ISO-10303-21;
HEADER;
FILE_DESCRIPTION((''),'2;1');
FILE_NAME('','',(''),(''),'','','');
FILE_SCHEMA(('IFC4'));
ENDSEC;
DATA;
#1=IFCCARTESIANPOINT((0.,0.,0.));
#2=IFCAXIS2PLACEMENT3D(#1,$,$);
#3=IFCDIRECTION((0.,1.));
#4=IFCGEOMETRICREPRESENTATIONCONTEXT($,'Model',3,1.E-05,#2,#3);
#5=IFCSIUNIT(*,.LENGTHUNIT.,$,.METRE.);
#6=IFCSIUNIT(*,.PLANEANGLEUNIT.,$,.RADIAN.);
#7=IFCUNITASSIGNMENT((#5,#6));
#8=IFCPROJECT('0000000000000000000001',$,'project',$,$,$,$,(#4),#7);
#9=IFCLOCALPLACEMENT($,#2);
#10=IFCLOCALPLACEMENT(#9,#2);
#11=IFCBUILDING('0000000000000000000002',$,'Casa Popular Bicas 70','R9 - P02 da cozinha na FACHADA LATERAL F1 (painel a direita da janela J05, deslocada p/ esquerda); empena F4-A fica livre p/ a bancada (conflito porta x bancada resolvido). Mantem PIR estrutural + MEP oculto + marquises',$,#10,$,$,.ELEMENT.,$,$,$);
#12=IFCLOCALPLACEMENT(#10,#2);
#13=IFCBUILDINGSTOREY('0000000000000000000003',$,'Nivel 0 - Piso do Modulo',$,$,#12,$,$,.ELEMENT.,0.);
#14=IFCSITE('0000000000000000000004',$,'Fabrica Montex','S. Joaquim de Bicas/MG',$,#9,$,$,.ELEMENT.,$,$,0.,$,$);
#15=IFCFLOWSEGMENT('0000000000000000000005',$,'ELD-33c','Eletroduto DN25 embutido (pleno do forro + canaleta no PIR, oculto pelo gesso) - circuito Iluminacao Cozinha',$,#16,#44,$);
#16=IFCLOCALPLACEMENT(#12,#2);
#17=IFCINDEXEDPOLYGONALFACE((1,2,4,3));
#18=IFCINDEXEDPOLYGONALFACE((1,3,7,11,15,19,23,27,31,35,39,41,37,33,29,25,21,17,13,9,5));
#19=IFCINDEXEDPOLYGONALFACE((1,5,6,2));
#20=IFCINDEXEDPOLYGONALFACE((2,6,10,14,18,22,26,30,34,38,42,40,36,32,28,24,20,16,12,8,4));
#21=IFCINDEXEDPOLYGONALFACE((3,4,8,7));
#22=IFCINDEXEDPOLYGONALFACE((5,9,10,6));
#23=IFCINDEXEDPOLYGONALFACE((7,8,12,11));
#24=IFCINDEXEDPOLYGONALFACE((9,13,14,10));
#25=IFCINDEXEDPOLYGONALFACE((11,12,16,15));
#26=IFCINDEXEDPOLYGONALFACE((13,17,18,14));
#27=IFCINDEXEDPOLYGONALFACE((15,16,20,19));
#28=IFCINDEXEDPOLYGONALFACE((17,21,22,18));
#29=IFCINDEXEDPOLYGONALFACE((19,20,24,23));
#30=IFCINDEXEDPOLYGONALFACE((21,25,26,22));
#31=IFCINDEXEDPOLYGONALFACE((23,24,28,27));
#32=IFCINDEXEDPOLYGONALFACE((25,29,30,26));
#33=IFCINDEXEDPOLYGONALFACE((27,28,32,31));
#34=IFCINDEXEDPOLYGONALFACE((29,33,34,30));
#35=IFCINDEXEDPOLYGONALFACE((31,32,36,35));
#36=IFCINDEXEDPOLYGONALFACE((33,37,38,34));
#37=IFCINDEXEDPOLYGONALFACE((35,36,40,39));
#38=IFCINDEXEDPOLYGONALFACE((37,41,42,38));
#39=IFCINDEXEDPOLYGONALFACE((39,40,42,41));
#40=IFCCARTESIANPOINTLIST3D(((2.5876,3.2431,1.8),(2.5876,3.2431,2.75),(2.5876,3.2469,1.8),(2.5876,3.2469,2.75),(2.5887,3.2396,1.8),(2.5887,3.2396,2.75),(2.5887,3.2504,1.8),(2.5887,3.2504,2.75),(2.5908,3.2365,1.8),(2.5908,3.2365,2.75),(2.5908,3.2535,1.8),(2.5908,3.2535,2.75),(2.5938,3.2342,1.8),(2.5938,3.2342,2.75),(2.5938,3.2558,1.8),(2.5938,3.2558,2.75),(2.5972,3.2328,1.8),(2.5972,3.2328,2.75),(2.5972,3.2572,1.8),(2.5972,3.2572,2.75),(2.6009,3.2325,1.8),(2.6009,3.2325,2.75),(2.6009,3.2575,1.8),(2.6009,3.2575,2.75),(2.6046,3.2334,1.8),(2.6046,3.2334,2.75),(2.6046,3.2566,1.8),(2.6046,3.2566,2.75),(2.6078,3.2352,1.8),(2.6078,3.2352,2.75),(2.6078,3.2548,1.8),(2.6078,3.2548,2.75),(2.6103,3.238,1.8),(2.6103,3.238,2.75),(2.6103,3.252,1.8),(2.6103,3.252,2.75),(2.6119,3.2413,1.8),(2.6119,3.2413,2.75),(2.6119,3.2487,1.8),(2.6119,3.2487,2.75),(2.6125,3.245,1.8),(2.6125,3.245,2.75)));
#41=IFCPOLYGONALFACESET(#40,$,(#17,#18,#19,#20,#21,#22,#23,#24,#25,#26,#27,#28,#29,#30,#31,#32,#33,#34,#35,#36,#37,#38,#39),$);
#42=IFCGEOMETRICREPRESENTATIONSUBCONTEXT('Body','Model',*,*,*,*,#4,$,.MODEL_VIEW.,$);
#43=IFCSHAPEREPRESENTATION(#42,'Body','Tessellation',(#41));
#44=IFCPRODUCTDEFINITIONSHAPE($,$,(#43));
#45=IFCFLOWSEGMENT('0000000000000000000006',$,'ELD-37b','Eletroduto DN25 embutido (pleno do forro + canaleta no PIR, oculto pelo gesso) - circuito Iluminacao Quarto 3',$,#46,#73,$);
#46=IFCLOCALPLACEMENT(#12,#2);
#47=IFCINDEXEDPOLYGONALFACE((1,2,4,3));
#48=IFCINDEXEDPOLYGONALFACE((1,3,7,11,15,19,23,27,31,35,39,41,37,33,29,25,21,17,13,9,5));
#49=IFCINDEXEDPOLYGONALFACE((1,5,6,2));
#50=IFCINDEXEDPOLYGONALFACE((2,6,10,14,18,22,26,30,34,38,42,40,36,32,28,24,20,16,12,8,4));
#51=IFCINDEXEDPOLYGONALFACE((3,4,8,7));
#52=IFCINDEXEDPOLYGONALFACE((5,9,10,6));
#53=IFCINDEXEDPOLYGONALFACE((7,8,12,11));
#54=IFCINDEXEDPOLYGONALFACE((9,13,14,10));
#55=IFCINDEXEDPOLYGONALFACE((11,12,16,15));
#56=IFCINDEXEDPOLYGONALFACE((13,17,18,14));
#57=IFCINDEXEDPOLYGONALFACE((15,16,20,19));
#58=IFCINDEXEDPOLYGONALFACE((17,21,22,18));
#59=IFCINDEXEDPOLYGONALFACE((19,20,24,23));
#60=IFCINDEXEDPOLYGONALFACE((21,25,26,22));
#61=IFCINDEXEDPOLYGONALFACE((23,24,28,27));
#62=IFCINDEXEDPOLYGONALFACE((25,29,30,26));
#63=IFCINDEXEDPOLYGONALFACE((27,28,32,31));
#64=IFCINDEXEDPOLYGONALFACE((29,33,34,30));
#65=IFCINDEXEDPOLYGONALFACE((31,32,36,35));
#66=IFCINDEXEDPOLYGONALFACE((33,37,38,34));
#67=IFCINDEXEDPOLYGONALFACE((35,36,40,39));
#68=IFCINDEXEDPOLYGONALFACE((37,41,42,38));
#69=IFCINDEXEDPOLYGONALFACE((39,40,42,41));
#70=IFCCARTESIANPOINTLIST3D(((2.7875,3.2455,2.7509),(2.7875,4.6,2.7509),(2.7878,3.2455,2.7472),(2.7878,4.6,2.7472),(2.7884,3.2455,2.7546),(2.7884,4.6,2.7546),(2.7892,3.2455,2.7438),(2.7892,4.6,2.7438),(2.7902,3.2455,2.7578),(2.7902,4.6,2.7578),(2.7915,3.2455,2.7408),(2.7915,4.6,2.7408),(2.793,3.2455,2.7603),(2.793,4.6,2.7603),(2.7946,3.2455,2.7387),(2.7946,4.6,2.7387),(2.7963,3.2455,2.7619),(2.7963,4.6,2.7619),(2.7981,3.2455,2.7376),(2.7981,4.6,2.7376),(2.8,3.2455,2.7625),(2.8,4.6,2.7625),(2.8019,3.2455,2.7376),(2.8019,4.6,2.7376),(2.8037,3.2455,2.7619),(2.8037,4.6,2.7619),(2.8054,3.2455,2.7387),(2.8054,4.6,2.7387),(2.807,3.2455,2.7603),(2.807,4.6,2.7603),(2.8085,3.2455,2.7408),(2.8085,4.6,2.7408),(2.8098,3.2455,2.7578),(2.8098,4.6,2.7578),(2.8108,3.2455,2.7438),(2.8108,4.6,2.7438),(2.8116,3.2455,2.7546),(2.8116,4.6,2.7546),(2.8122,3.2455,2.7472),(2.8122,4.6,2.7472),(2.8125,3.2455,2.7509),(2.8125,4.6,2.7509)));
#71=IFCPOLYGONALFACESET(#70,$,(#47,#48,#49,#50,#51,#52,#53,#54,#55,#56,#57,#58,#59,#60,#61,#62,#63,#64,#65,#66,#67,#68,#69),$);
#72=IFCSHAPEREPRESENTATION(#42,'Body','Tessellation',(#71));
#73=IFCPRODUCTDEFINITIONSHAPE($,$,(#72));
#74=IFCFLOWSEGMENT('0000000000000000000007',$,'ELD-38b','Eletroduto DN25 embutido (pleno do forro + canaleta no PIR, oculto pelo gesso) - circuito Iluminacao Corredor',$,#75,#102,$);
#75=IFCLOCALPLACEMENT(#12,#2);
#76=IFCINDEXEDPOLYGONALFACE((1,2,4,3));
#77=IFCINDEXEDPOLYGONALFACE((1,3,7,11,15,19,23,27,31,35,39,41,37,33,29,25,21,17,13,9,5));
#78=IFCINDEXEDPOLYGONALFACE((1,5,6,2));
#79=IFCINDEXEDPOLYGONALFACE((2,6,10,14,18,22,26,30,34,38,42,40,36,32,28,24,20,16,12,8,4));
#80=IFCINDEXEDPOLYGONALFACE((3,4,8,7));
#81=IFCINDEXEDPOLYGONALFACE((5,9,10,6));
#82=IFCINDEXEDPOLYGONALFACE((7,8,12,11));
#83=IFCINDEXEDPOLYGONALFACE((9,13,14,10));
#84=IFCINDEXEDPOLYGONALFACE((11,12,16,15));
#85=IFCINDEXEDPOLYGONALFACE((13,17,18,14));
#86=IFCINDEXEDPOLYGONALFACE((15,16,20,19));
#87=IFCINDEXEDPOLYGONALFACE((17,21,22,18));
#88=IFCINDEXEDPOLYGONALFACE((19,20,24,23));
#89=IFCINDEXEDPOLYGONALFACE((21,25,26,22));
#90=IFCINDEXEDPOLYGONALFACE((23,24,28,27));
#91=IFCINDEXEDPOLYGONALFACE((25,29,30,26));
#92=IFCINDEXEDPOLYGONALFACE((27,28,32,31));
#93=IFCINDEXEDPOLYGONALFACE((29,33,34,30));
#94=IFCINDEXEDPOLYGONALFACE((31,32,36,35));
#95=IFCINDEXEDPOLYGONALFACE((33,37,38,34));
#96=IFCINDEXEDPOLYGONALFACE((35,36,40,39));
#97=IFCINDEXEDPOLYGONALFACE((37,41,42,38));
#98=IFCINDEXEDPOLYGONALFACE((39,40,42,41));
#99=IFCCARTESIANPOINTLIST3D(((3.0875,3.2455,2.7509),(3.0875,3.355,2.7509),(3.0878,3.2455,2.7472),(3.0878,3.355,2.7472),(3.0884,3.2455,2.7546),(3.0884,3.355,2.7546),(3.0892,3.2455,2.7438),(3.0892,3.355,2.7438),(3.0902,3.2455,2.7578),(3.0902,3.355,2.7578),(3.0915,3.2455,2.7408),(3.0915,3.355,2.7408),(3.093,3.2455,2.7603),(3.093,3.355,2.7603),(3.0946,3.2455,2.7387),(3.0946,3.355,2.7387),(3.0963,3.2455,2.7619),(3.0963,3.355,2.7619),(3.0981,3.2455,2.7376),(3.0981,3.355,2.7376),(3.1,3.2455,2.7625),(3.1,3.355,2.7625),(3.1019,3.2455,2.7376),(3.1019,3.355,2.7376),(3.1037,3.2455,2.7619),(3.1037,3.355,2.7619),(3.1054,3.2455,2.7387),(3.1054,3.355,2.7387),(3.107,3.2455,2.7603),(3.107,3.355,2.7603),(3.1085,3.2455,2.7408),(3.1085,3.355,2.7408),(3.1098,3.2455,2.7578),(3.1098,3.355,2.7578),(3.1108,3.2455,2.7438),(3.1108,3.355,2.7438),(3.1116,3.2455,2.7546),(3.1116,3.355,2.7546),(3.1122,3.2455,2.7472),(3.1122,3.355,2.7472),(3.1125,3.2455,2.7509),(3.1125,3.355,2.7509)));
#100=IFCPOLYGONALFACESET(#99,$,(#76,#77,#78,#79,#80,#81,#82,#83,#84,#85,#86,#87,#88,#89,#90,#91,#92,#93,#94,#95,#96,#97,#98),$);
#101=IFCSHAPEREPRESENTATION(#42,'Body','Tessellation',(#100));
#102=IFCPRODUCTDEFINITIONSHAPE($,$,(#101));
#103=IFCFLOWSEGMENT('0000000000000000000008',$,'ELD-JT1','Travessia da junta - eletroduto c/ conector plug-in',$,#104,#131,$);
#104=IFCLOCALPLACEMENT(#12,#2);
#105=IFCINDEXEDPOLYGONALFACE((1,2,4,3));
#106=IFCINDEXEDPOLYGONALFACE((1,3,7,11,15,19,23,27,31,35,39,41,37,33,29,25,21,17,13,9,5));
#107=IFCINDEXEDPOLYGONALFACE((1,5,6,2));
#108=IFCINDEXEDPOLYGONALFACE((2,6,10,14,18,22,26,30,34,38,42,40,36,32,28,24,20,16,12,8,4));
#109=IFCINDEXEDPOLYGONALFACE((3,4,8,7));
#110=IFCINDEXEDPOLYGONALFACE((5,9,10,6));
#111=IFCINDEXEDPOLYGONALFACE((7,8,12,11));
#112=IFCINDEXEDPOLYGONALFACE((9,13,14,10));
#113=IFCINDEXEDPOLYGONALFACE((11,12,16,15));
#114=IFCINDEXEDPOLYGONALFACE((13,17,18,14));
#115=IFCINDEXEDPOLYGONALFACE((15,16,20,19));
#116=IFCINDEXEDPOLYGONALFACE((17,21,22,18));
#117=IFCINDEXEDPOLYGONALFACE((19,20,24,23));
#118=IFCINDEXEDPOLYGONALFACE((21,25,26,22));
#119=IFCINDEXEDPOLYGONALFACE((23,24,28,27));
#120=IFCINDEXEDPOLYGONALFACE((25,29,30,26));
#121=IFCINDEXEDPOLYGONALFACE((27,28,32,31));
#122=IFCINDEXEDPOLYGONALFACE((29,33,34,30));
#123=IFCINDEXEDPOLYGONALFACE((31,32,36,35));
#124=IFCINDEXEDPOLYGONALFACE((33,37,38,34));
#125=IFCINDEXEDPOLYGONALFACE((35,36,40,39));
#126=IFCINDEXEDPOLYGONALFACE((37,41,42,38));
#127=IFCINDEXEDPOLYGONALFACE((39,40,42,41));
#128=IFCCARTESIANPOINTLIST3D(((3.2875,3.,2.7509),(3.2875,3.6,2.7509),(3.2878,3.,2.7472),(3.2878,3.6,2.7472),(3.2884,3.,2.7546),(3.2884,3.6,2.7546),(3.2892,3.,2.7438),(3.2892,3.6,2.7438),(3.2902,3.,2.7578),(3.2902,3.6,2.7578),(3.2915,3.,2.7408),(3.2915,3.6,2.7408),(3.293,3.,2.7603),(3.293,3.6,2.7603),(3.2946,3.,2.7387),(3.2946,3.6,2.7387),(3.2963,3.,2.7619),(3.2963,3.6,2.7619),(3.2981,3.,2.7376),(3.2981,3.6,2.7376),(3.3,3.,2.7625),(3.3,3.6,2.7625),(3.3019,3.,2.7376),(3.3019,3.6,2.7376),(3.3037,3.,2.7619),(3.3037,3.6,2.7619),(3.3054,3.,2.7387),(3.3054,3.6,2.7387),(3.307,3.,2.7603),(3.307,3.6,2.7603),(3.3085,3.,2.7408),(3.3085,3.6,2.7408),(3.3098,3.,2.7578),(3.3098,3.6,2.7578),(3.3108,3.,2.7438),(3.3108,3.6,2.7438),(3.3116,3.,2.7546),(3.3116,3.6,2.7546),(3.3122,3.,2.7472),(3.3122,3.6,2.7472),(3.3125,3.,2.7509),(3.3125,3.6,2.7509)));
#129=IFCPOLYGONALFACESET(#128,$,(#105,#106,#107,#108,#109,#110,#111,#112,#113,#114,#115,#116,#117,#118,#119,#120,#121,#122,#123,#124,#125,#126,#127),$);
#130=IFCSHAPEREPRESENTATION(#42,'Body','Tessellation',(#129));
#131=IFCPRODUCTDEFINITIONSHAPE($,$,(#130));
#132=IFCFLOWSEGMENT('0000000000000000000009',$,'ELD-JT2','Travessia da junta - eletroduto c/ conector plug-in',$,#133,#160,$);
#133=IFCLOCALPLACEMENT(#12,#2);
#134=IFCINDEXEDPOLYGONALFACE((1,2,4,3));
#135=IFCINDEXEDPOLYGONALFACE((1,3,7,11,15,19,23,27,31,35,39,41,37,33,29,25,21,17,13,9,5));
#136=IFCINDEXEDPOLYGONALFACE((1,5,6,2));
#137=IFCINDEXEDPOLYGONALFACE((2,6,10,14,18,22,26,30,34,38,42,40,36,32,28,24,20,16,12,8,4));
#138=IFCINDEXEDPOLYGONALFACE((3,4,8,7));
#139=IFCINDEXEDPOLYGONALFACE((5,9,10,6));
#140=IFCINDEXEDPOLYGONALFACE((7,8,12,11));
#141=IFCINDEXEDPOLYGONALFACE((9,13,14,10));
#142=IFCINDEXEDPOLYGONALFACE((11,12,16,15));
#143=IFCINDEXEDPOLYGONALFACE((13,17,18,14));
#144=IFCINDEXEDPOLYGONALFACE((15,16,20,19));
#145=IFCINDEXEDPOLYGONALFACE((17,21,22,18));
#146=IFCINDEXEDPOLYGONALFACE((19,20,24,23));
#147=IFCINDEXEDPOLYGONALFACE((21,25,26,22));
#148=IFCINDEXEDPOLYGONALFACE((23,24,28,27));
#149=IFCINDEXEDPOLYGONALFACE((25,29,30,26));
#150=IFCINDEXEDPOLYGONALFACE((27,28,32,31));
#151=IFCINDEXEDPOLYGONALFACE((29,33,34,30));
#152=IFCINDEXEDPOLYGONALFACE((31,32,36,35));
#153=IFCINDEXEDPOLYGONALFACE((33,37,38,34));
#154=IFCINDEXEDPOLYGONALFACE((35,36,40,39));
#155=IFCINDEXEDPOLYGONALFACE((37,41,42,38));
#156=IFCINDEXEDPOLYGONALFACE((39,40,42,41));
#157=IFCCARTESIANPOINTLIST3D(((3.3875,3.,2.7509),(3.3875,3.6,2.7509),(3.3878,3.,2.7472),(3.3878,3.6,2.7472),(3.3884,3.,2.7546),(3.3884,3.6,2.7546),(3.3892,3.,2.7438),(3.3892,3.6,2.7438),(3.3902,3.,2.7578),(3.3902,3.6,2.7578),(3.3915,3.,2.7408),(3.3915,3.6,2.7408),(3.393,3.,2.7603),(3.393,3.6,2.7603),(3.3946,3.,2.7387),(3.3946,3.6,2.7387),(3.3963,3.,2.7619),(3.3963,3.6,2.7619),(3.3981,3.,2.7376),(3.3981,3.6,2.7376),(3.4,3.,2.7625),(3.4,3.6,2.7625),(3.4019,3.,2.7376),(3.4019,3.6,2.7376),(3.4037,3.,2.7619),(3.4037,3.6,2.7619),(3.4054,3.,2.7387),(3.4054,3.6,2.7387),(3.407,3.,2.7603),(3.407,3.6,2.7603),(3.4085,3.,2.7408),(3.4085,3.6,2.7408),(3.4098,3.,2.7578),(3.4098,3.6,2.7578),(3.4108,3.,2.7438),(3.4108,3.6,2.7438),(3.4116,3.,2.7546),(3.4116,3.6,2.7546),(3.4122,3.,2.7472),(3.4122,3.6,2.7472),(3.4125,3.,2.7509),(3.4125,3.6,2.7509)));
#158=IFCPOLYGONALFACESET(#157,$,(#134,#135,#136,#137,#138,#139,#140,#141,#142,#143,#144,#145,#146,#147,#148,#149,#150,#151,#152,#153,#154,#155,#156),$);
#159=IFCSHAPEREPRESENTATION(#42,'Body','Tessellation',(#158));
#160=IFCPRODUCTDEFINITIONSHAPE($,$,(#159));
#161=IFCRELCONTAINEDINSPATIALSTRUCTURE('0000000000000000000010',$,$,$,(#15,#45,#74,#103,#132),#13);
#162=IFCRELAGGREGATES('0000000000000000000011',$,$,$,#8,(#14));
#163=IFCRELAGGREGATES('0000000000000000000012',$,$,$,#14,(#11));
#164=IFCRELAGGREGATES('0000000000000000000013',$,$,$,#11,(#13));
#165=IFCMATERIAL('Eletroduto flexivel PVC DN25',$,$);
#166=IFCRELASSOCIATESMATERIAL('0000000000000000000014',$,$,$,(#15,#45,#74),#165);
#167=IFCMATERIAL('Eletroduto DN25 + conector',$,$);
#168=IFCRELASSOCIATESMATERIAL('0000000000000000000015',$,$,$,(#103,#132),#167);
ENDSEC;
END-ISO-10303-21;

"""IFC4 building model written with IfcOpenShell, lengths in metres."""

from ifc_helpers import new_model, si_unit, direction, frame, origin, origin_2d, place, context, subcontext, project, spatial, circle, extrude, material, element, save


model = new_model("IFC4")

# Units and contexts
model_context = context("Model", 3, precision=1e-05, world=origin(), true_north=direction((0.0, 1.0)))
body_context = subcontext(model_context, "Body", "Model", "MODEL_VIEW")
ifc_project = project(units=[si_unit("LENGTHUNIT", "METRE"), si_unit("PLANEANGLEUNIT", "RADIAN")], contexts=[model_context])

# Site, building, storey
site_placement = place(None, origin())
site = spatial("IfcSite", under=ifc_project, at=site_placement, Name="Fabrica Montex", Description="S. Joaquim de Bicas/MG", CompositionType="ELEMENT", RefElevation=0.0)
building_placement = place(site_placement, origin())
building = spatial("IfcBuilding", under=site, at=building_placement, Name="Casa Popular Bicas 70", Description="R9 - P02 da cozinha na FACHADA LATERAL F1 (painel a direita da janela J05, deslocada p/ esquerda); empena F4-A fica livre p/ a bancada (conflito porta x bancada resolvido). Mantem PIR estrutural + MEP oculto + marquises", CompositionType="ELEMENT")
storey_placement = place(building_placement, origin())
storey = spatial("IfcBuildingStorey", under=building, at=storey_placement, Name="Nivel 0 - Piso do Modulo", CompositionType="ELEMENT", Elevation=0.0)

# Flow segments
ifc_material_1 = material(Name="Eletroduto flexivel PVC DN25")
flow_segment_1_placement = place(storey_placement, frame((2.6, 3.245, 2.75), z_axis=(0.0, 0.0, -1.0), x_axis=(1.0, 0.0, 0.0)))
element("IfcFlowSegment", 1, at=flow_segment_1_placement, inside=storey, material=ifc_material_1, Name="ELD-33c", Description="Eletroduto DN25 embutido (pleno do forro + canaleta no PIR, oculto pelo gesso) - circuito Iluminacao Cozinha", context=body_context, shape_type="SweptSolid", body=[
    extrude(circle(Radius=0.0125, at=origin_2d()), origin(), (0.0, 0.0, 1.0), 0.95),
])
flow_segment_2_placement = place(storey_placement, frame((2.8, 3.2455, 2.75), z_axis=(0.0, 1.0, 0.0), x_axis=(0.0, 0.0, 1.0)))
element("IfcFlowSegment", 2, at=flow_segment_2_placement, inside=storey, material=ifc_material_1, Name="ELD-37b", Description="Eletroduto DN25 embutido (pleno do forro + canaleta no PIR, oculto pelo gesso) - circuito Iluminacao Quarto 3", context=body_context, shape_type="SweptSolid", body=[
    extrude(circle(Radius=0.0125, at=origin_2d()), origin(), (0.0, 0.0, 1.0), 1.3545),
])
flow_segment_3_placement = place(storey_placement, frame((3.1, 3.2455, 2.75), z_axis=(0.0, 1.0, 0.0), x_axis=(0.0, 0.0, 1.0)))
element("IfcFlowSegment", 3, at=flow_segment_3_placement, inside=storey, material=ifc_material_1, Name="ELD-38b", Description="Eletroduto DN25 embutido (pleno do forro + canaleta no PIR, oculto pelo gesso) - circuito Iluminacao Corredor", context=body_context, shape_type="SweptSolid", body=[
    extrude(circle(Radius=0.0125, at=origin_2d()), origin(), (0.0, 0.0, 1.0), 0.1095),
])
ifc_material_2 = material(Name="Eletroduto DN25 + conector")
for number, where, z_axis, x_axis, name in (
    (4, (3.3, 3.0, 2.75), (0.0, 1.0, 0.0), (0.0, 0.0, 1.0), "ELD-JT1"),
    (5, (3.4, 3.0, 2.75), (0.0, 1.0, 0.0), (0.0, 0.0, 1.0), "ELD-JT2"),
):
    element("IfcFlowSegment", number, at=place(storey_placement, frame(where, z_axis=z_axis, x_axis=x_axis)), inside=storey, material=ifc_material_2, Name=name, Description="Travessia da junta - eletroduto c/ conector plug-in", context=body_context, shape_type="SweptSolid", body=[
        extrude(circle(Radius=0.0125, at=origin_2d()), origin(), (0.0, 0.0, 1.0), 0.6),
    ])

save(model, "model.ifc")
